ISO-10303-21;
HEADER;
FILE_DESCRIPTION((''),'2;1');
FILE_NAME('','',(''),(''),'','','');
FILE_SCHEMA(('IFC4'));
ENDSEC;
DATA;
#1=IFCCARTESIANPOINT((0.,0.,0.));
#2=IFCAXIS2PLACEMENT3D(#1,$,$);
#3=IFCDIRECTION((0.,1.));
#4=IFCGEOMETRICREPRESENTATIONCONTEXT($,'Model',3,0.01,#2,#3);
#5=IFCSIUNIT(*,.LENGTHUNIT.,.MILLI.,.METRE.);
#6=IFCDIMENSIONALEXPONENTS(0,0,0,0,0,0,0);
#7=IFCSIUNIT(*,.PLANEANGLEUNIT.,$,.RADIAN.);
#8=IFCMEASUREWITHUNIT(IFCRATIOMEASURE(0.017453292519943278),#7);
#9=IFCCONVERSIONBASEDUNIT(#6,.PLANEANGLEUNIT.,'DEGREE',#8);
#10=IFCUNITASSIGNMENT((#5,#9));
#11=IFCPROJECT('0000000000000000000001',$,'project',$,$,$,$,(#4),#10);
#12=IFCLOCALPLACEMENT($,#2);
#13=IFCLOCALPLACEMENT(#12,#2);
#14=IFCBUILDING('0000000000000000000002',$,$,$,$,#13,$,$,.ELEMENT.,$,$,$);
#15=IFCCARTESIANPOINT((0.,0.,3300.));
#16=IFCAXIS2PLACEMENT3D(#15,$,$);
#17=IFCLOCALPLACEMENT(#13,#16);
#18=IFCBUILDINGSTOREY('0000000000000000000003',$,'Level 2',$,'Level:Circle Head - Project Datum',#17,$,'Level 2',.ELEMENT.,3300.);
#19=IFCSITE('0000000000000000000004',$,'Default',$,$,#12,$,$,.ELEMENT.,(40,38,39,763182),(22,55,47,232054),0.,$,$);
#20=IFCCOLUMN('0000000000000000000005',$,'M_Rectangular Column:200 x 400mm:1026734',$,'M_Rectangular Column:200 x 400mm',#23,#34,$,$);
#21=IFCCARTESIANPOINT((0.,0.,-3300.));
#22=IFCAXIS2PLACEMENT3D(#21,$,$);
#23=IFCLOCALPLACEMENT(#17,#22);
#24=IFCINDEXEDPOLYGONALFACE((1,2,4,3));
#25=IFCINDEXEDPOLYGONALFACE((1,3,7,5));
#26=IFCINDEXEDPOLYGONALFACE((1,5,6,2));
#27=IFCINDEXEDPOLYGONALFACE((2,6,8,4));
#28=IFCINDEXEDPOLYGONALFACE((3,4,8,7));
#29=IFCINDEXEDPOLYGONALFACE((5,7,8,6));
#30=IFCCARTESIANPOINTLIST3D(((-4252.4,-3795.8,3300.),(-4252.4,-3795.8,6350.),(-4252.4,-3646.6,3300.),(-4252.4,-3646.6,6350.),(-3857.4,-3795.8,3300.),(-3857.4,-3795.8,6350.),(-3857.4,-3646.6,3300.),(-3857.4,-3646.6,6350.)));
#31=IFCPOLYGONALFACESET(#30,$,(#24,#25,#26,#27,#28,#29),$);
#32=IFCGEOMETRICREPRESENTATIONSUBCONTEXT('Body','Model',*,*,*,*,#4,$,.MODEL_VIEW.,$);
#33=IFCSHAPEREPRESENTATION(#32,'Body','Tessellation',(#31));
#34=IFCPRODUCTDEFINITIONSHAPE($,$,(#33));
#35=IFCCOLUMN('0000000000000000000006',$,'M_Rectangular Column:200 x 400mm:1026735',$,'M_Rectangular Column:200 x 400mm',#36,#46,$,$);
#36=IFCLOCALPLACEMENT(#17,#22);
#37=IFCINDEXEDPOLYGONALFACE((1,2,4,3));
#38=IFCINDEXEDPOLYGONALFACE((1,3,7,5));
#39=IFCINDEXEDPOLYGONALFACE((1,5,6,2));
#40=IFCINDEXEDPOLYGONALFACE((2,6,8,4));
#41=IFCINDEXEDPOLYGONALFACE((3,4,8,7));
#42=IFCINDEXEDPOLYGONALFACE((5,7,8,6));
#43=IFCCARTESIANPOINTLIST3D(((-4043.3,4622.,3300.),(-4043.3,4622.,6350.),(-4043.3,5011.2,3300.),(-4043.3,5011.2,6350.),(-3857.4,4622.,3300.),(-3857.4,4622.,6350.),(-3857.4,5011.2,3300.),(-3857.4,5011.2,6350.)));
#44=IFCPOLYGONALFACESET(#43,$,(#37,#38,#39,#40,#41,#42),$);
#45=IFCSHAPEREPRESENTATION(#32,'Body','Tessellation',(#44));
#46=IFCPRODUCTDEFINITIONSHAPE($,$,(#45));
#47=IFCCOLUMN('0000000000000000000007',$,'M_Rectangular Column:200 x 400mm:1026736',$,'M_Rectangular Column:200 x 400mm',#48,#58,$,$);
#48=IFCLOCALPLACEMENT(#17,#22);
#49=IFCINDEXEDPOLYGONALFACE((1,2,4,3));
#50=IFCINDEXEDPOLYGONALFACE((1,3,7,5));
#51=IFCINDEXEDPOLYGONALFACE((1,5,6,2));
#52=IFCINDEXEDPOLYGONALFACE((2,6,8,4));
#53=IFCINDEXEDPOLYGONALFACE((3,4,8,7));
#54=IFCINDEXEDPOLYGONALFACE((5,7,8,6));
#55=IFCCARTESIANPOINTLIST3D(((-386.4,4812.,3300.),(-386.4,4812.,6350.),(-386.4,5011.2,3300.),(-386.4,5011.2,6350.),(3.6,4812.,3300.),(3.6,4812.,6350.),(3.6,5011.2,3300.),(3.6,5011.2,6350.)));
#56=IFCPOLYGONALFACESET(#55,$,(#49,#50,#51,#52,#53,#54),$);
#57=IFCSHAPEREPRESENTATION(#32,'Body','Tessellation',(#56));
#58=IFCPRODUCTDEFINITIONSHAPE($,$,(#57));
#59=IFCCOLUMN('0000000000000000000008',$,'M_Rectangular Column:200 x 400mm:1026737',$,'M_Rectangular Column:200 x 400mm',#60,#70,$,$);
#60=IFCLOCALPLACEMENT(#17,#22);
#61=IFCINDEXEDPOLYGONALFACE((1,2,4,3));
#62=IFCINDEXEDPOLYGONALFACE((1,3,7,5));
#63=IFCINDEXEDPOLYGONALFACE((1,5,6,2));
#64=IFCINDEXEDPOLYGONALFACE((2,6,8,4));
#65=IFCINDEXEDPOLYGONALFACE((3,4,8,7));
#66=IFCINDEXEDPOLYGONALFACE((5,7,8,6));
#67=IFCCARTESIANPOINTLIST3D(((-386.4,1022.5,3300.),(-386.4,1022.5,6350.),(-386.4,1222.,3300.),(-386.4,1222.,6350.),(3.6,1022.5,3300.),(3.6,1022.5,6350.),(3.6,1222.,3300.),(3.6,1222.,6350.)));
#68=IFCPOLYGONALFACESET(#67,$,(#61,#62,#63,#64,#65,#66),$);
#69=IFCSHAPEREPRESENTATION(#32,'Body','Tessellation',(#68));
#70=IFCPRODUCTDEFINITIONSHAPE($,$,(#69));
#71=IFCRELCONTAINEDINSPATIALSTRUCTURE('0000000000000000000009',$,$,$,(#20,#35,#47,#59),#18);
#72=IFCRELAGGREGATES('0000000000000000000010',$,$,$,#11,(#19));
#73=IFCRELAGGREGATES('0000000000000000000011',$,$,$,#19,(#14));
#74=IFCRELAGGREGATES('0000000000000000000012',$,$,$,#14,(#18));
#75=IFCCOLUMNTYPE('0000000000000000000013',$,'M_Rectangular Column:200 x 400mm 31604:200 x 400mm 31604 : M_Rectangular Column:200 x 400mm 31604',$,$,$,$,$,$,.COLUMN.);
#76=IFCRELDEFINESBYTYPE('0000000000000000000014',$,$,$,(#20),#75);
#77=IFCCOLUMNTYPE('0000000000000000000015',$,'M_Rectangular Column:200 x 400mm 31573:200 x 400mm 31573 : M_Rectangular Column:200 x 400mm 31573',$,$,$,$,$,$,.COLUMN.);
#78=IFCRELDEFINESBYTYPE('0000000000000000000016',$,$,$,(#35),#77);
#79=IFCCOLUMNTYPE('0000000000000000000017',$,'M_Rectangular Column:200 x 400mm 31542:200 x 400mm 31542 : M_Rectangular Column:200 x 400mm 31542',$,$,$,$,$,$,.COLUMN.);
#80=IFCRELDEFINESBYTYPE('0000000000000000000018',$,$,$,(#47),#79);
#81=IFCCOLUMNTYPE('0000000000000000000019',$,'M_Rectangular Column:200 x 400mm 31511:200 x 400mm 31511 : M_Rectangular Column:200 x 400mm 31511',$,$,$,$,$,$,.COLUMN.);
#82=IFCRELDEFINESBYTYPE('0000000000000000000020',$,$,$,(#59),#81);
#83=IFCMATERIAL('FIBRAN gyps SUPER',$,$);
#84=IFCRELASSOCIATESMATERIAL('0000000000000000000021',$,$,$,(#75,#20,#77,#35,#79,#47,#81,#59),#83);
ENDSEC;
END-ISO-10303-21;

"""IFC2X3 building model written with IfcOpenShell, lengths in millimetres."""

from ifc_helpers import new_model, entity, si_unit, converted_unit, direction, frame, frame_2d, origin, origin_2d_with_axis, place, context, subcontext, project, spatial, rectangle, extrude, source, transform, mapped, material, type_object, type_shapes, element, save


model = new_model("IFC2X3")

# Units and contexts
model_context = context("Model", 3, precision=0.01, world=origin(), true_north=direction((0.0, 1.0)))
body_context = subcontext(model_context, "Body", "Model", "MODEL_VIEW")
ifc_project = project(units=[si_unit("LENGTHUNIT", "METRE", prefix="MILLI"), converted_unit("PLANEANGLEUNIT", "DEGREE", entity("IfcRatioMeasure", 0.017453292519943278), si_unit("PLANEANGLEUNIT", "RADIAN"), dimensions=[0, 0, 0, 0, 0, 0, 0])], contexts=[model_context])

# Site, building, storey
site_placement = place(None, origin())
site = spatial("IfcSite", under=ifc_project, at=site_placement, Name="Default", CompositionType="ELEMENT", RefLatitude=(40, 38, 39, 763182), RefLongitude=(22, 55, 47, 232054), RefElevation=0.0)
building_placement = place(site_placement, origin())
building = spatial("IfcBuilding", under=site, at=building_placement, CompositionType="ELEMENT")
storey_placement = place(building_placement, frame((0.0, 0.0, 3300.0)))
storey = spatial("IfcBuildingStorey", under=building, at=storey_placement, Name="Level 2", ObjectType="Level:Circle Head - Project Datum", LongName="Level 2", CompositionType="ELEMENT", Elevation=3300.0)

# Columns
ifc_material_1 = material(Name="FIBRAN gyps SUPER")
column_type_1 = type_object("IfcColumnType", Name="M_Rectangular Column:200 x 400mm 31604:200 x 400mm 31604 : M_Rectangular Column:200 x 400mm 31604", PredefinedType="COLUMN", material=ifc_material_1)
shared_shape_1 = source(origin(), body_context, "Body", "SweptSolid", [
    extrude(rectangle(XDim=149.2, YDim=395.0, at=origin_2d_with_axis()), frame((-4054.9, -3721.2, 3300.0), z_axis=(0.0, 0.0, 1.0), x_axis=(0.0, -1.0, 0.0)), (0.0, 0.0, 1.0), 3050.0),
])
type_shapes(column_type_1, [shared_shape_1])
column_1_placement = place(storey_placement, frame((0.0, 0.0, -3300.0)))
element("IfcColumn", 1, at=column_1_placement, inside=storey, type_object=column_type_1, material=ifc_material_1, Name="M_Rectangular Column:200 x 400mm:1026734", ObjectType="M_Rectangular Column:200 x 400mm", context=body_context, shape_type="MappedRepresentation", body=[
    mapped(shared_shape_1, transform((0.0, 0.0, 0.0), scale=1.0)),
])
column_type_2 = type_object("IfcColumnType", Name="M_Rectangular Column:200 x 400mm 31573:200 x 400mm 31573 : M_Rectangular Column:200 x 400mm 31573", PredefinedType="COLUMN", material=ifc_material_1)
shared_shape_2 = source(origin(), body_context, "Body", "SweptSolid", [
    extrude(rectangle(XDim=389.1, YDim=186.0, at=frame_2d((0.0, 0.0), x_axis=(1.0, 0.0))), frame((-3950.3, 4816.6, 3300.0), z_axis=(0.0, 0.0, 1.0), x_axis=(0.0, -1.0, 0.0)), (0.0, 0.0, 1.0), 3050.0),
])
type_shapes(column_type_2, [shared_shape_2])
column_2_placement = place(storey_placement, frame((0.0, 0.0, -3300.0)))
element("IfcColumn", 2, at=column_2_placement, inside=storey, type_object=column_type_2, material=ifc_material_1, Name="M_Rectangular Column:200 x 400mm:1026735", ObjectType="M_Rectangular Column:200 x 400mm", context=body_context, shape_type="MappedRepresentation", body=[
    mapped(shared_shape_2, transform((0.0, 0.0, 0.0), scale=1.0)),
])
column_type_3 = type_object("IfcColumnType", Name="M_Rectangular Column:200 x 400mm 31542:200 x 400mm 31542 : M_Rectangular Column:200 x 400mm 31542", PredefinedType="COLUMN", material=ifc_material_1)
shared_shape_3 = source(origin(), body_context, "Body", "SweptSolid", [
    extrude(rectangle(XDim=199.1, YDim=390.0, at=origin_2d_with_axis()), frame((-191.4, 4911.6, 3300.0), z_axis=(0.0, 0.0, 1.0), x_axis=(0.0, -1.0, 0.0)), (0.0, 0.0, 1.0), 3050.0),
])
type_shapes(column_type_3, [shared_shape_3])
column_3_placement = place(storey_placement, frame((0.0, 0.0, -3300.0)))
element("IfcColumn", 3, at=column_3_placement, inside=storey, type_object=column_type_3, material=ifc_material_1, Name="M_Rectangular Column:200 x 400mm:1026736", ObjectType="M_Rectangular Column:200 x 400mm", context=body_context, shape_type="MappedRepresentation", body=[
    mapped(shared_shape_3, transform((0.0, 0.0, 0.0), scale=1.0)),
])
column_type_4 = type_object("IfcColumnType", Name="M_Rectangular Column:200 x 400mm 31511:200 x 400mm 31511 : M_Rectangular Column:200 x 400mm 31511", PredefinedType="COLUMN", material=ifc_material_1)
shared_shape_4 = source(origin(), body_context, "Body", "SweptSolid", [
    extrude(rectangle(XDim=199.5, YDim=390.0, at=frame_2d((0.0, 0.0), x_axis=(1.0, 0.0))), frame((-191.4, 1122.3, 3300.0), z_axis=(0.0, 0.0, 1.0), x_axis=(0.0, -1.0, 0.0)), (0.0, 0.0, 1.0), 3050.0),
])
type_shapes(column_type_4, [shared_shape_4])
column_4_placement = place(storey_placement, frame((0.0, 0.0, -3300.0)))
element("IfcColumn", 4, at=column_4_placement, inside=storey, type_object=column_type_4, material=ifc_material_1, Name="M_Rectangular Column:200 x 400mm:1026737", ObjectType="M_Rectangular Column:200 x 400mm", context=body_context, shape_type="MappedRepresentation", body=[
    mapped(shared_shape_4, transform((0.0, 0.0, 0.0), scale=1.0)),
])

save(model, "model.ifc")
